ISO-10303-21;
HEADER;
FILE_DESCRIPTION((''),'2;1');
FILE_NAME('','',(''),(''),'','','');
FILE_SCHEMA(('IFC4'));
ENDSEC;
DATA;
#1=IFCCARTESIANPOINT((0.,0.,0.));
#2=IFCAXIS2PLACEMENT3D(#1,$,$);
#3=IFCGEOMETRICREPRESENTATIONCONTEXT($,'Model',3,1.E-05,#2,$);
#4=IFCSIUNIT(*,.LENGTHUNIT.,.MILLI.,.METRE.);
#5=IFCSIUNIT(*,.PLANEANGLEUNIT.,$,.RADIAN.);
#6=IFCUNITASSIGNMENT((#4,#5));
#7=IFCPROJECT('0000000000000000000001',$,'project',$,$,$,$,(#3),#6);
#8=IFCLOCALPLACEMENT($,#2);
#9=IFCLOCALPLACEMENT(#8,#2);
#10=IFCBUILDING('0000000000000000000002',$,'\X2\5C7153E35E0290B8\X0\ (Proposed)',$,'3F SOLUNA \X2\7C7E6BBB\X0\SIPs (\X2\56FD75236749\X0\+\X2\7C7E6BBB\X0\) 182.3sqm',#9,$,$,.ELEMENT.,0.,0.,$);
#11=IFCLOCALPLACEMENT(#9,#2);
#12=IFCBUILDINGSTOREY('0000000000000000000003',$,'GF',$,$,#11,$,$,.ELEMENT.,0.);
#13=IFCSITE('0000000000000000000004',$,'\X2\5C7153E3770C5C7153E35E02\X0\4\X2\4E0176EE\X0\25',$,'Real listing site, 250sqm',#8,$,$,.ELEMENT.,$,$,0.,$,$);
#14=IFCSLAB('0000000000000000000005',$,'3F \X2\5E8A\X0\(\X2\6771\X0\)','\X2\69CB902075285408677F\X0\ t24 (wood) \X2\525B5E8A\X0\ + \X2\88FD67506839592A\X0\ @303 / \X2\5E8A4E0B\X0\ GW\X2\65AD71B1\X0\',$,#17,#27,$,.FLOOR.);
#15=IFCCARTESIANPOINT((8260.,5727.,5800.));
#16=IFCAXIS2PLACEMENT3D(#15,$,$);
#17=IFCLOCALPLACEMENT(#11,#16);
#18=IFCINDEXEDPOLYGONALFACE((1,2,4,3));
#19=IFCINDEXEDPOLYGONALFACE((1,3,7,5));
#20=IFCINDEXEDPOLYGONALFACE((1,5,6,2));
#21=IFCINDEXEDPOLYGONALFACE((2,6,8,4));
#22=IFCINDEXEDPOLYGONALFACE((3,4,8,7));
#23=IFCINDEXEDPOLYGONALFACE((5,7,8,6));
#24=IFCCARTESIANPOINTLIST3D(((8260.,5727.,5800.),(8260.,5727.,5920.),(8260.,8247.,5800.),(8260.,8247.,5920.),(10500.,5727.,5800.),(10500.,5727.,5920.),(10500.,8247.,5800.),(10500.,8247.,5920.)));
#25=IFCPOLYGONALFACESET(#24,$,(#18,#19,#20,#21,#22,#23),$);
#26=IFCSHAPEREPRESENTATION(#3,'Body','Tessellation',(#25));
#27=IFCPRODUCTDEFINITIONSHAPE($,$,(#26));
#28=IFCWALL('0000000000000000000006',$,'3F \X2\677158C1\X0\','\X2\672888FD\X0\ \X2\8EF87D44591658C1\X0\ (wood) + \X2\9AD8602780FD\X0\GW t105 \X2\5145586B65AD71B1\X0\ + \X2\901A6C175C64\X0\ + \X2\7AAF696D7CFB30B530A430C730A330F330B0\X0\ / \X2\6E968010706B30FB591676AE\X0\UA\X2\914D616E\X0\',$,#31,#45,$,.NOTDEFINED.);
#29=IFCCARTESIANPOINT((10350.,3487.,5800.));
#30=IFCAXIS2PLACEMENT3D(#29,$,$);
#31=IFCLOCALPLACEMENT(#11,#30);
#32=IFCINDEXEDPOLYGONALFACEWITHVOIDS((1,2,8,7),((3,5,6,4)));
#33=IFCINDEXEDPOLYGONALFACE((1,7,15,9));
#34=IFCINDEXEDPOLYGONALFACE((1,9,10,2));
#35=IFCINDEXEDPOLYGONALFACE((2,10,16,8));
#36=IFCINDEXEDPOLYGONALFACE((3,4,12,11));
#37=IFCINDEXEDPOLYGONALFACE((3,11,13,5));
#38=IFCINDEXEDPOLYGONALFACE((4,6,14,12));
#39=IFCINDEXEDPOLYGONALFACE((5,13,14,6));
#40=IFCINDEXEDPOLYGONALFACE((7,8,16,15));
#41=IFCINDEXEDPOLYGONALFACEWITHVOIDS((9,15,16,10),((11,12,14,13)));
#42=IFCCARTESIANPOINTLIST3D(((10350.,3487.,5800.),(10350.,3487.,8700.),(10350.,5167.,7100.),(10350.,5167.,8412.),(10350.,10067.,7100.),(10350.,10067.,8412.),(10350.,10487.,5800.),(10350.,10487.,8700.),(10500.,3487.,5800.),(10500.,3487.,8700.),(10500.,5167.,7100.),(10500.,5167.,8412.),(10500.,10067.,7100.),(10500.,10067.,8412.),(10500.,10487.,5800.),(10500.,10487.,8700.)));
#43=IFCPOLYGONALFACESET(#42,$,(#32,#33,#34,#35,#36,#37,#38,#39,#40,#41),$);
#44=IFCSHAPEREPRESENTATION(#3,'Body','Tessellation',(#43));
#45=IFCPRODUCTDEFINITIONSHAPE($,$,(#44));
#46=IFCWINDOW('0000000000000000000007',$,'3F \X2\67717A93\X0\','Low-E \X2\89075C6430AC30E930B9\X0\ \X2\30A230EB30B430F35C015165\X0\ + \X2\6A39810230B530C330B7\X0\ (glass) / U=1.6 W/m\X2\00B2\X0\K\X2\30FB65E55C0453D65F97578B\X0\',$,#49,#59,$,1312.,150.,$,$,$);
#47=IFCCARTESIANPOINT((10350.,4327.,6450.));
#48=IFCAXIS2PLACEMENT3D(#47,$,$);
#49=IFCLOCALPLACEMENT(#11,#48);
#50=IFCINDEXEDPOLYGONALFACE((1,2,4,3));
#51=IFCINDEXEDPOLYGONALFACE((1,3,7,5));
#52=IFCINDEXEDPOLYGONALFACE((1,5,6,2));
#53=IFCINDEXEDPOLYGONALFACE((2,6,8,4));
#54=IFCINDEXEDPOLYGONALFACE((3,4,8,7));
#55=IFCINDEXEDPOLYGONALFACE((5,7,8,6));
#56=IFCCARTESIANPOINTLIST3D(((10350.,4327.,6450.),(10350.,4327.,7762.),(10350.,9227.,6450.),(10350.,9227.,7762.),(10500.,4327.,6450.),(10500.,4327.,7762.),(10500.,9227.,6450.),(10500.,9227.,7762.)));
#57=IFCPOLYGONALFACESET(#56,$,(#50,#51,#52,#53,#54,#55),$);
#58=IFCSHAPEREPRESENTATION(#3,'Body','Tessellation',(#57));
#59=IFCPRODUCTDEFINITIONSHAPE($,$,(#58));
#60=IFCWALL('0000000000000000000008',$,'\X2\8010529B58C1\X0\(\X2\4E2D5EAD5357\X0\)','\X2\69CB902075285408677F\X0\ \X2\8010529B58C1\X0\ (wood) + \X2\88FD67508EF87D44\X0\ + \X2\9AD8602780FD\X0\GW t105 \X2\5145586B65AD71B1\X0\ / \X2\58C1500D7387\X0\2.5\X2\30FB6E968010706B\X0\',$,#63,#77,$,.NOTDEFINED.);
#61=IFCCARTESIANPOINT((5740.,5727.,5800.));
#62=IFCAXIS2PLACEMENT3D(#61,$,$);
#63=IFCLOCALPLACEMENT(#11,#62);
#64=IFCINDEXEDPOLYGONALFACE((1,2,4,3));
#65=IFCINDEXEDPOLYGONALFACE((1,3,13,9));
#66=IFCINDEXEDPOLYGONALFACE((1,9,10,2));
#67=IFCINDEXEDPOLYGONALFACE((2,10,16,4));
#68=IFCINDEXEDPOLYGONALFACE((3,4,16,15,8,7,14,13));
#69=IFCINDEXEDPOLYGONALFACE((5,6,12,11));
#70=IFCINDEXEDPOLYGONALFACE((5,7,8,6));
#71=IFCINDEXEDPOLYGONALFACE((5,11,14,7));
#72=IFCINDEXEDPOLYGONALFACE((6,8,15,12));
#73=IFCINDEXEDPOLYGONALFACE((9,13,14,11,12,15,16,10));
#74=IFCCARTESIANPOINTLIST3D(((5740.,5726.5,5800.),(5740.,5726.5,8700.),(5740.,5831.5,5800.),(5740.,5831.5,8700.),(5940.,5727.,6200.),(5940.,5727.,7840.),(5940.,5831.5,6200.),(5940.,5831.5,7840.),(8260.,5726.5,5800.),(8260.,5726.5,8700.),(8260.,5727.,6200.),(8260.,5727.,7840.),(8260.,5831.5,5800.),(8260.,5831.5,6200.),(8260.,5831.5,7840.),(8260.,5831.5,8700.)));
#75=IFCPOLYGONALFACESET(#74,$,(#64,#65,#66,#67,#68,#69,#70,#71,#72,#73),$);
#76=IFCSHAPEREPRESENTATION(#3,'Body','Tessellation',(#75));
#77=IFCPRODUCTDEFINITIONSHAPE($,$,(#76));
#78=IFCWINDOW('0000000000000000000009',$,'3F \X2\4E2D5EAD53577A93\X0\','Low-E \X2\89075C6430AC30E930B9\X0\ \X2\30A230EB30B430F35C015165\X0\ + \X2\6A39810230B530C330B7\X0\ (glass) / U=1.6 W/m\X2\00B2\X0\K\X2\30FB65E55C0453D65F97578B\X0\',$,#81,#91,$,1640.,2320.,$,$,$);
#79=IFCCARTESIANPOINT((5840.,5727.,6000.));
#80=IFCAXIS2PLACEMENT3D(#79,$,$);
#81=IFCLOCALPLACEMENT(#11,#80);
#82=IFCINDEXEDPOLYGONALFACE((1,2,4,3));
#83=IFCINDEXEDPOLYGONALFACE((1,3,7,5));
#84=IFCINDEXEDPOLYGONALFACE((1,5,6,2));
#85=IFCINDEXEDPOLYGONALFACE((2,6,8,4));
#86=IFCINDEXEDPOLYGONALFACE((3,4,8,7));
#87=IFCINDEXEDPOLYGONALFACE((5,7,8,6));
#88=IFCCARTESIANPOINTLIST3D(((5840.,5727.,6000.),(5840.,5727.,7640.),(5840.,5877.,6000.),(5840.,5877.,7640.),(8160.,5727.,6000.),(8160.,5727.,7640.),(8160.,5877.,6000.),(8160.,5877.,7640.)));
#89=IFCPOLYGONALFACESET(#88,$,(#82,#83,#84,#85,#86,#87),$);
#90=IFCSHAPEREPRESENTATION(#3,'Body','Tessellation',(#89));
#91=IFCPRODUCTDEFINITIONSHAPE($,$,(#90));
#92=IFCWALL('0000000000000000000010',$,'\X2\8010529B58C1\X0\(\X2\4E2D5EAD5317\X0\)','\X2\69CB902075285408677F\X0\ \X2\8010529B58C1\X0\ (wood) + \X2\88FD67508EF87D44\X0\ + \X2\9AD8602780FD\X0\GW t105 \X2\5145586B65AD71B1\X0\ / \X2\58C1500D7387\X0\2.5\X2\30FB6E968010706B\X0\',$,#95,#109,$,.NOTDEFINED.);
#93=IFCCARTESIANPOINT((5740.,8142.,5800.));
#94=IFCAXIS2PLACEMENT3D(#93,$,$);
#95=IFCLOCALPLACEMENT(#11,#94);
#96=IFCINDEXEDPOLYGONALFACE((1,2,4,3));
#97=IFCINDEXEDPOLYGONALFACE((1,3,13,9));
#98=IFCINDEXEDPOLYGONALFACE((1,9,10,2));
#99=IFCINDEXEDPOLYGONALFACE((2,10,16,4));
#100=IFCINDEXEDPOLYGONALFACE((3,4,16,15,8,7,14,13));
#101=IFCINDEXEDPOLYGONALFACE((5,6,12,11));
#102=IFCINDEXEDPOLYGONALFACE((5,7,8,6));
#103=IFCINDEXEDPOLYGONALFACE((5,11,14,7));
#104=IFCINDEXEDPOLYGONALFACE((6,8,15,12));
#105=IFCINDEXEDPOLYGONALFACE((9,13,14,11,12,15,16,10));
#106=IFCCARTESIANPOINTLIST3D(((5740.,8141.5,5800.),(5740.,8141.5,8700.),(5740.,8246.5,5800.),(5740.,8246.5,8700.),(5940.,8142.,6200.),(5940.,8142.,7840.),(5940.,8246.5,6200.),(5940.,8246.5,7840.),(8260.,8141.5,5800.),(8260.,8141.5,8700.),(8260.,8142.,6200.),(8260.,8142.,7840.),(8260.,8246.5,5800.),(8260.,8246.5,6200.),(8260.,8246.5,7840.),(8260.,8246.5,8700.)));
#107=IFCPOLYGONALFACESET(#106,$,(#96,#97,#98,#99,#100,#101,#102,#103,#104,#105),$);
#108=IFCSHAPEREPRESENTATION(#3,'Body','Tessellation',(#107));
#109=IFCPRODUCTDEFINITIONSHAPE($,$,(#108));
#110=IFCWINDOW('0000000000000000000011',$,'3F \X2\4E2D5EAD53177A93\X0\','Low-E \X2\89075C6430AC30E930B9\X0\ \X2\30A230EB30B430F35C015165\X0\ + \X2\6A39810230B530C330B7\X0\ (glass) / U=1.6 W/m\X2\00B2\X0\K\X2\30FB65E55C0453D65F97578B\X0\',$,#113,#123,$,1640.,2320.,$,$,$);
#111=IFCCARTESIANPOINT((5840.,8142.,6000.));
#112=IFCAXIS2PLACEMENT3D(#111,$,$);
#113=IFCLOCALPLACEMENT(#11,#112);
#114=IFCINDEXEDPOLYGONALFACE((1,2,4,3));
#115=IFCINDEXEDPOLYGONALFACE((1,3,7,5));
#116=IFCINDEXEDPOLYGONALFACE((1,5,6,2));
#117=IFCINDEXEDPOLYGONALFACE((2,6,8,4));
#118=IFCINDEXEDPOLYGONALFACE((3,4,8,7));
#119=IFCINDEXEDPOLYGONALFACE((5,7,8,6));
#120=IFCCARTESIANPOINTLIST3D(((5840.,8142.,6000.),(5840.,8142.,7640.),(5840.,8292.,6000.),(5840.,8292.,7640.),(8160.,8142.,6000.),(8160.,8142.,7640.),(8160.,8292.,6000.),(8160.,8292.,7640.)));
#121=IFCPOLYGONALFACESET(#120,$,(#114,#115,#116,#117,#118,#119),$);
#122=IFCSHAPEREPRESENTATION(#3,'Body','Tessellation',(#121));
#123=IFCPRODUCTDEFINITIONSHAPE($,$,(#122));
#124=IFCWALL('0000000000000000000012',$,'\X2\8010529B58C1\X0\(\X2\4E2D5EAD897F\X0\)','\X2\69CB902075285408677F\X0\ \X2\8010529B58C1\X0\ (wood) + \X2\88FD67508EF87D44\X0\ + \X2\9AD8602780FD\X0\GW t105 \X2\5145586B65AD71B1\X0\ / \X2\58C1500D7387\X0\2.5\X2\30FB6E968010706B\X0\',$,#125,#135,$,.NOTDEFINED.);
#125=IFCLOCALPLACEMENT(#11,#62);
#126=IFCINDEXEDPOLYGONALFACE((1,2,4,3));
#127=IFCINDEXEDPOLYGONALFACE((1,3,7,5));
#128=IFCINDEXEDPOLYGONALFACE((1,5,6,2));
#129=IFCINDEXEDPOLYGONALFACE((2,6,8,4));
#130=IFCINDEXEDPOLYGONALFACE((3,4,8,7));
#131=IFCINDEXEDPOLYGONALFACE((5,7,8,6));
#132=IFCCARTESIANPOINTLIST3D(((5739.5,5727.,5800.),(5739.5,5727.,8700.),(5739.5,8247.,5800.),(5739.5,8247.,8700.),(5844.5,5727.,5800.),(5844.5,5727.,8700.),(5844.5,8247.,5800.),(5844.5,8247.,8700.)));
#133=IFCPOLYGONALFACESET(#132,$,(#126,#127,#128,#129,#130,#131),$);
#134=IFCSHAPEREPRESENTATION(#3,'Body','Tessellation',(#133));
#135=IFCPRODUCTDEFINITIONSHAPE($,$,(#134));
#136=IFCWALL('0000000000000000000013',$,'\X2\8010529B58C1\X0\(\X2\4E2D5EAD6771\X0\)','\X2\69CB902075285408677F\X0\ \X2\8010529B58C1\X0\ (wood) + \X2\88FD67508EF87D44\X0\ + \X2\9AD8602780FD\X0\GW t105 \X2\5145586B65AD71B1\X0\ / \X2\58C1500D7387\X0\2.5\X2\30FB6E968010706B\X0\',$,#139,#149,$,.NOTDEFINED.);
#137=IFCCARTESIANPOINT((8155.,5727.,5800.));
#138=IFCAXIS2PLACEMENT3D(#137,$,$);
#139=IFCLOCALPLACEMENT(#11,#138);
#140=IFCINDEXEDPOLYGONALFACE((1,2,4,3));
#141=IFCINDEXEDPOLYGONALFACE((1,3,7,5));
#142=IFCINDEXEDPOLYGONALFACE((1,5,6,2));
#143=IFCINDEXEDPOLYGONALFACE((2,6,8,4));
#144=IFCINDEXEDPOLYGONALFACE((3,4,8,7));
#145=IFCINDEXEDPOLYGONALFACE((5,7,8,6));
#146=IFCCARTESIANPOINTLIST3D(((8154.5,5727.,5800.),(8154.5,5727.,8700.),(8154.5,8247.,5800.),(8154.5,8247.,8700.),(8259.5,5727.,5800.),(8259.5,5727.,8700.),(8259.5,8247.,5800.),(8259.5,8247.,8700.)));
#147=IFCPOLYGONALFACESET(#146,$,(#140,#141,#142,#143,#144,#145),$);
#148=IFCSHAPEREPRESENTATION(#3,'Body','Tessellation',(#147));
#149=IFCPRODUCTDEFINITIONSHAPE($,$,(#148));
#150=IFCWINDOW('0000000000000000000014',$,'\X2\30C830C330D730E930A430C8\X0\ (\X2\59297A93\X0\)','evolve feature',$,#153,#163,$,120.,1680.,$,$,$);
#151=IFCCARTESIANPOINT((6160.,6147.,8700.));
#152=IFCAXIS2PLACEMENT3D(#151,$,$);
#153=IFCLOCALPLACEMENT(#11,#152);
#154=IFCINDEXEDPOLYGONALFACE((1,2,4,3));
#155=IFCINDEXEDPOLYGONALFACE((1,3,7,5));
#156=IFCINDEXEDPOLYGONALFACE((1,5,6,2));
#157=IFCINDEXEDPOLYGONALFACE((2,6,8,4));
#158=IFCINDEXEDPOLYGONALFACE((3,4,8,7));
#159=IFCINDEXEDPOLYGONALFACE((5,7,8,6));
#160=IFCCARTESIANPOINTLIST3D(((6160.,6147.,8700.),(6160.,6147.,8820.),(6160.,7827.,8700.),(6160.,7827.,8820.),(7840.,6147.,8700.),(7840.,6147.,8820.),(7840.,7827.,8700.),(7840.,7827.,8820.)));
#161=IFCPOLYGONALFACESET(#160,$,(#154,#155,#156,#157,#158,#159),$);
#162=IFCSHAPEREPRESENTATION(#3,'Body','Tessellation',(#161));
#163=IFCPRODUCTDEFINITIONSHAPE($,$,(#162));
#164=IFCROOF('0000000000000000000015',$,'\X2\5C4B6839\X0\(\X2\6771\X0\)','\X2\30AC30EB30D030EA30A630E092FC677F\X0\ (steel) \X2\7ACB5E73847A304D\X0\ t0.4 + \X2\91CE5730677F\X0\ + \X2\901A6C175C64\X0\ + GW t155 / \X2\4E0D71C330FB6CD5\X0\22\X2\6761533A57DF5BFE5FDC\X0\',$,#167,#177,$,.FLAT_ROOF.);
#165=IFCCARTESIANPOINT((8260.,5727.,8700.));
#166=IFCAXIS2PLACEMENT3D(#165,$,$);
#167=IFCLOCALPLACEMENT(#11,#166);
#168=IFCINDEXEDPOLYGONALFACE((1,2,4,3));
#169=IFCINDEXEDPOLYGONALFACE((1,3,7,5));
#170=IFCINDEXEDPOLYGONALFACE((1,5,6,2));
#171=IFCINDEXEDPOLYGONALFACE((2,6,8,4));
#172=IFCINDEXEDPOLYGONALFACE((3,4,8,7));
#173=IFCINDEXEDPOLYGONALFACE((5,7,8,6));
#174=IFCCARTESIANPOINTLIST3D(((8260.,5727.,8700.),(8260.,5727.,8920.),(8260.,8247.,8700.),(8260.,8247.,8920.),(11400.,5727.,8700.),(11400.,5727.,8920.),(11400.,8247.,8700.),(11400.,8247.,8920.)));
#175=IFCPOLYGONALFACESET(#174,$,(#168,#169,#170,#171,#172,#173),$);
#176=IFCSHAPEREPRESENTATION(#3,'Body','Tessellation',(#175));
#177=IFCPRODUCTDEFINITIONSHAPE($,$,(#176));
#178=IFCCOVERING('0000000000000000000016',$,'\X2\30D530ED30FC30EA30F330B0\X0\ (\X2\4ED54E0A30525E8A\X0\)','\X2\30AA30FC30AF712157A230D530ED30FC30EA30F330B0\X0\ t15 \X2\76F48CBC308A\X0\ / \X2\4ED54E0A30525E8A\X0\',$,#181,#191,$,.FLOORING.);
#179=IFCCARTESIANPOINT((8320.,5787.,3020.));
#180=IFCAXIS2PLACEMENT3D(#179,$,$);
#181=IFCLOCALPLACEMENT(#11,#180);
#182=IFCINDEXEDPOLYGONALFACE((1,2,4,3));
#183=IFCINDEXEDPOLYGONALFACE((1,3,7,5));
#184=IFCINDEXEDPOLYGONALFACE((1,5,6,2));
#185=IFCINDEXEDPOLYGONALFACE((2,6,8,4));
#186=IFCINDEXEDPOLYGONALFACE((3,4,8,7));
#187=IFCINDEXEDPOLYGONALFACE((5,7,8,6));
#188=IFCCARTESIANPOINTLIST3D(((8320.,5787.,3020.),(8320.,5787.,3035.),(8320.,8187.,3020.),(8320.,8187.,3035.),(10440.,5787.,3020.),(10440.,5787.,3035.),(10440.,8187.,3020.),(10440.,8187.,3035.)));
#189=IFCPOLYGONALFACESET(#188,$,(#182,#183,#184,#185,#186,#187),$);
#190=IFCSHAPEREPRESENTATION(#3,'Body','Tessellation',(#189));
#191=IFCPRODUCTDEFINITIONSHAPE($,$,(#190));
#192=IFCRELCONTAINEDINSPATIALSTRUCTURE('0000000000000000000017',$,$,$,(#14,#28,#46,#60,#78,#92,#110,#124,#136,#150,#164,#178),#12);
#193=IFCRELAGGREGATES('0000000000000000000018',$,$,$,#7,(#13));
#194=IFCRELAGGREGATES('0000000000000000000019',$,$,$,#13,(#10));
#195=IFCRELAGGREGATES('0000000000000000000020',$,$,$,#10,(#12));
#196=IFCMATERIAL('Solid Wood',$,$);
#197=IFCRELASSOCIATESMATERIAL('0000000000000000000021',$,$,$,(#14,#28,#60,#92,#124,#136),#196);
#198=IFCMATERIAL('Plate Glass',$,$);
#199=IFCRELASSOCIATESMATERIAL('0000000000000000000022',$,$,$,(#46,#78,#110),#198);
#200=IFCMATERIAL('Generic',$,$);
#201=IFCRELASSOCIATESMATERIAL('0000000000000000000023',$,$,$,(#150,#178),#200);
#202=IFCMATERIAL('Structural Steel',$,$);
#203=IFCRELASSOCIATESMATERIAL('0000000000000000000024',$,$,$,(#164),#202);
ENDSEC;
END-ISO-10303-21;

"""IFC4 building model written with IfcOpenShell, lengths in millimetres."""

from ifc_helpers import new_model, si_unit, frame, frame_2d, origin, place, context, project, spatial, rectangle, extrude, material, element, fill, save


model = new_model("IFC4")

# Units and contexts
model_context = context("Model", 3, precision=1e-05, world=origin())
ifc_project = project(units=[si_unit("LENGTHUNIT", "METRE", prefix="MILLI"), si_unit("PLANEANGLEUNIT", "RADIAN")], contexts=[model_context])

# Site, building, storey
site_placement = place(None, origin())
site = spatial("IfcSite", under=ifc_project, at=site_placement, Name="山口県山口市4丁目25", ObjectType="Real listing site, 250sqm", CompositionType="ELEMENT", RefElevation=0.0)
building_placement = place(site_placement, origin())
building = spatial("IfcBuilding", under=site, at=building_placement, Name="山口市邸 (Proposed)", ObjectType="3F SOLUNA 籾殻SIPs (国産杉+籾殻) 182.3sqm", CompositionType="ELEMENT", ElevationOfRefHeight=0.0, ElevationOfTerrain=0.0)
storey_placement = place(building_placement, origin())
storey = spatial("IfcBuildingStorey", under=building, at=storey_placement, Name="GF", CompositionType="ELEMENT", Elevation=0.0)

# Slab
ifc_material_1 = material(Name="Solid Wood")
slab_placement = place(storey_placement, frame((8260.0, 5727.0, 5800.0)))
element("IfcSlab", 1, at=slab_placement, inside=storey, material=ifc_material_1, Name="3F 床(東)", Description="構造用合板 t24 (wood) 剛床 + 製材根太 @303 / 床下 GW断熱", PredefinedType="FLOOR", context=model_context, shape_type="SweptSolid", body=[
    extrude(rectangle(XDim=2240.0, YDim=2520.0, at=frame_2d((1120.0, 1260.0))), frame((8260.0, 5727.0, 5800.0)), (0.0, 0.0, 1.0), 120.0),
])

# Walls, openings, windows
wall_1_placement = place(storey_placement, frame((10350.0, 3487.0, 5800.0)))
wall_1 = element("IfcWall", 2, at=wall_1_placement, inside=storey, material=ifc_material_1, Name="3F 東壁", Description="木製 軸組外壁 (wood) + 高性能GW t105 充填断熱 + 通気層 + 窯業系サイディング / 準耐火・外皮UA配慮", PredefinedType="NOTDEFINED", context=model_context, shape_type="SweptSolid", body=[
    extrude(rectangle(XDim=150.0, YDim=7000.0, at=frame_2d((75.0, 3500.0))), frame((10350.0, 3487.0, 5800.0)), (0.0, 0.0, 1.0), 2900.0),
])
opening_1_placement = place(storey_placement, frame((10350.0, 4327.0, 6450.0)))
opening_1 = element("IfcOpeningElement", 3, at=opening_1_placement, cuts=wall_1, PredefinedType="NOTDEFINED", context=model_context, shape_type="SweptSolid", body=[
    extrude(rectangle(XDim=150.0, YDim=4900.0, at=frame_2d((75.0, 2450.0))), frame((10350.0, 4327.0, 6450.0)), (0.0, 0.0, 1.0), 1312.0),
])
ifc_material_2 = material(Name="Plate Glass")
window_1_placement = place(storey_placement, frame((10350.0, 4327.0, 6450.0)))
window_1 = element("IfcWindow", 4, at=window_1_placement, inside=storey, material=ifc_material_2, Name="3F 東窓", Description="Low-E 複層ガラス アルゴン封入 + 樹脂サッシ (glass) / U=1.6 W/m²K・日射取得型", OverallHeight=1312.0, OverallWidth=150.0, context=model_context, shape_type="SweptSolid", body=[
    extrude(rectangle(XDim=150.0, YDim=4900.0, at=frame_2d((75.0, 2450.0))), frame((10350.0, 4327.0, 6450.0)), (0.0, 0.0, 1.0), 1312.0),
])
fill(opening_1, window_1)
wall_2_placement = place(storey_placement, frame((5740.0, 5727.0, 5800.0)))
wall_2 = element("IfcWall", 5, at=wall_2_placement, inside=storey, material=ifc_material_1, Name="耐力壁(中庭南)", Description="構造用合板 耐力壁 (wood) + 製材軸組 + 高性能GW t105 充填断熱 / 壁倍率2.5・準耐火", PredefinedType="NOTDEFINED", context=model_context, shape_type="SweptSolid", body=[
    extrude(rectangle(XDim=2520.0, YDim=105.0, at=frame_2d((1260.0, 52.0))), frame((5740.0, 5727.0, 5800.0)), (0.0, 0.0, 1.0), 2900.0),
])
opening_2_placement = place(storey_placement, frame((5840.0, 5727.0, 6000.0)))
opening_2 = element("IfcOpeningElement", 6, at=opening_2_placement, cuts=wall_2, PredefinedType="NOTDEFINED", context=model_context, shape_type="SweptSolid", body=[
    extrude(rectangle(XDim=2320.0, YDim=150.0, at=frame_2d((1160.0, 75.0))), frame((5840.0, 5727.0, 6000.0)), (0.0, 0.0, 1.0), 1640.0),
])
window_2_placement = place(storey_placement, frame((5840.0, 5727.0, 6000.0)))
window_2 = element("IfcWindow", 7, at=window_2_placement, inside=storey, material=ifc_material_2, Name="3F 中庭南窓", Description="Low-E 複層ガラス アルゴン封入 + 樹脂サッシ (glass) / U=1.6 W/m²K・日射取得型", OverallHeight=1640.0, OverallWidth=2320.0, context=model_context, shape_type="SweptSolid", body=[
    extrude(rectangle(XDim=2320.0, YDim=150.0, at=frame_2d((1160.0, 75.0))), frame((5840.0, 5727.0, 6000.0)), (0.0, 0.0, 1.0), 1640.0),
])
fill(opening_2, window_2)
wall_3_placement = place(storey_placement, frame((5740.0, 8142.0, 5800.0)))
wall_3 = element("IfcWall", 8, at=wall_3_placement, inside=storey, material=ifc_material_1, Name="耐力壁(中庭北)", Description="構造用合板 耐力壁 (wood) + 製材軸組 + 高性能GW t105 充填断熱 / 壁倍率2.5・準耐火", PredefinedType="NOTDEFINED", context=model_context, shape_type="SweptSolid", body=[
    extrude(rectangle(XDim=2520.0, YDim=105.0, at=frame_2d((1260.0, 52.0))), frame((5740.0, 8142.0, 5800.0)), (0.0, 0.0, 1.0), 2900.0),
])
opening_3_placement = place(storey_placement, frame((5840.0, 8142.0, 6000.0)))
opening_3 = element("IfcOpeningElement", 9, at=opening_3_placement, cuts=wall_3, PredefinedType="NOTDEFINED", context=model_context, shape_type="SweptSolid", body=[
    extrude(rectangle(XDim=2320.0, YDim=150.0, at=frame_2d((1160.0, 75.0))), frame((5840.0, 8142.0, 6000.0)), (0.0, 0.0, 1.0), 1640.0),
])
window_3_placement = place(storey_placement, frame((5840.0, 8142.0, 6000.0)))
window_3 = element("IfcWindow", 10, at=window_3_placement, inside=storey, material=ifc_material_2, Name="3F 中庭北窓", Description="Low-E 複層ガラス アルゴン封入 + 樹脂サッシ (glass) / U=1.6 W/m²K・日射取得型", OverallHeight=1640.0, OverallWidth=2320.0, context=model_context, shape_type="SweptSolid", body=[
    extrude(rectangle(XDim=2320.0, YDim=150.0, at=frame_2d((1160.0, 75.0))), frame((5840.0, 8142.0, 6000.0)), (0.0, 0.0, 1.0), 1640.0),
])
fill(opening_3, window_3)

# Walls
wall_4_placement = place(storey_placement, frame((5740.0, 5727.0, 5800.0)))
element("IfcWall", 11, at=wall_4_placement, inside=storey, material=ifc_material_1, Name="耐力壁(中庭西)", Description="構造用合板 耐力壁 (wood) + 製材軸組 + 高性能GW t105 充填断熱 / 壁倍率2.5・準耐火", PredefinedType="NOTDEFINED", context=model_context, shape_type="SweptSolid", body=[
    extrude(rectangle(XDim=105.0, YDim=2520.0, at=frame_2d((52.0, 1260.0))), frame((5740.0, 5727.0, 5800.0)), (0.0, 0.0, 1.0), 2900.0),
])
wall_5_placement = place(storey_placement, frame((8155.0, 5727.0, 5800.0)))
element("IfcWall", 12, at=wall_5_placement, inside=storey, material=ifc_material_1, Name="耐力壁(中庭東)", Description="構造用合板 耐力壁 (wood) + 製材軸組 + 高性能GW t105 充填断熱 / 壁倍率2.5・準耐火", PredefinedType="NOTDEFINED", context=model_context, shape_type="SweptSolid", body=[
    extrude(rectangle(XDim=105.0, YDim=2520.0, at=frame_2d((52.0, 1260.0))), frame((8155.0, 5727.0, 5800.0)), (0.0, 0.0, 1.0), 2900.0),
])

# Window
ifc_material_3 = material(Name="Generic")
window_4_placement = place(storey_placement, frame((6160.0, 6147.0, 8700.0)))
element("IfcWindow", 13, at=window_4_placement, inside=storey, material=ifc_material_3, Name="トップライト (天窓)", Description="evolve feature", OverallHeight=120.0, OverallWidth=1680.0, context=model_context, shape_type="SweptSolid", body=[
    extrude(rectangle(XDim=1680.0, YDim=1680.0, at=frame_2d((840.0, 840.0))), frame((6160.0, 6147.0, 8700.0)), (0.0, 0.0, 1.0), 120.0),
])

# Roof
ifc_material_4 = material(Name="Structural Steel")
for number, where, name in (
    (14, (8260.0, 5727.0, 8700.0), "屋根(東)"),
):
    element("IfcRoof", number, at=place(storey_placement, frame(where)), inside=storey, material=ifc_material_4, Name=name, Description="ガルバリウム鋼板 (steel) 立平葺き t0.4 + 野地板 + 通気層 + GW t155 / 不燃・法22条区域対応", PredefinedType="FLAT_ROOF", context=model_context, shape_type="SweptSolid", body=[
        extrude(rectangle(XDim=3140.0, YDim=2520.0, at=frame_2d((1570.0, 1260.0))), frame((8260.0, 5727.0, 8700.0)), (0.0, 0.0, 1.0), 220.0),
    ])

# Covering
covering_1_placement = place(storey_placement, frame((8320.0, 5787.0, 3020.0)))
element("IfcCovering", 15, at=covering_1_placement, inside=storey, material=ifc_material_3, Name="フローリング (仕上げ床)", Description="オーク無垢フローリング t15 直貼り / 仕上げ床", PredefinedType="FLOORING", context=model_context, shape_type="SweptSolid", body=[
    extrude(rectangle(XDim=2120.0, YDim=2400.0, at=frame_2d((1060.0, 1200.0))), frame((8320.0, 5787.0, 3020.0)), (0.0, 0.0, 1.0), 15.0),
])

save(model, "model.ifc")
